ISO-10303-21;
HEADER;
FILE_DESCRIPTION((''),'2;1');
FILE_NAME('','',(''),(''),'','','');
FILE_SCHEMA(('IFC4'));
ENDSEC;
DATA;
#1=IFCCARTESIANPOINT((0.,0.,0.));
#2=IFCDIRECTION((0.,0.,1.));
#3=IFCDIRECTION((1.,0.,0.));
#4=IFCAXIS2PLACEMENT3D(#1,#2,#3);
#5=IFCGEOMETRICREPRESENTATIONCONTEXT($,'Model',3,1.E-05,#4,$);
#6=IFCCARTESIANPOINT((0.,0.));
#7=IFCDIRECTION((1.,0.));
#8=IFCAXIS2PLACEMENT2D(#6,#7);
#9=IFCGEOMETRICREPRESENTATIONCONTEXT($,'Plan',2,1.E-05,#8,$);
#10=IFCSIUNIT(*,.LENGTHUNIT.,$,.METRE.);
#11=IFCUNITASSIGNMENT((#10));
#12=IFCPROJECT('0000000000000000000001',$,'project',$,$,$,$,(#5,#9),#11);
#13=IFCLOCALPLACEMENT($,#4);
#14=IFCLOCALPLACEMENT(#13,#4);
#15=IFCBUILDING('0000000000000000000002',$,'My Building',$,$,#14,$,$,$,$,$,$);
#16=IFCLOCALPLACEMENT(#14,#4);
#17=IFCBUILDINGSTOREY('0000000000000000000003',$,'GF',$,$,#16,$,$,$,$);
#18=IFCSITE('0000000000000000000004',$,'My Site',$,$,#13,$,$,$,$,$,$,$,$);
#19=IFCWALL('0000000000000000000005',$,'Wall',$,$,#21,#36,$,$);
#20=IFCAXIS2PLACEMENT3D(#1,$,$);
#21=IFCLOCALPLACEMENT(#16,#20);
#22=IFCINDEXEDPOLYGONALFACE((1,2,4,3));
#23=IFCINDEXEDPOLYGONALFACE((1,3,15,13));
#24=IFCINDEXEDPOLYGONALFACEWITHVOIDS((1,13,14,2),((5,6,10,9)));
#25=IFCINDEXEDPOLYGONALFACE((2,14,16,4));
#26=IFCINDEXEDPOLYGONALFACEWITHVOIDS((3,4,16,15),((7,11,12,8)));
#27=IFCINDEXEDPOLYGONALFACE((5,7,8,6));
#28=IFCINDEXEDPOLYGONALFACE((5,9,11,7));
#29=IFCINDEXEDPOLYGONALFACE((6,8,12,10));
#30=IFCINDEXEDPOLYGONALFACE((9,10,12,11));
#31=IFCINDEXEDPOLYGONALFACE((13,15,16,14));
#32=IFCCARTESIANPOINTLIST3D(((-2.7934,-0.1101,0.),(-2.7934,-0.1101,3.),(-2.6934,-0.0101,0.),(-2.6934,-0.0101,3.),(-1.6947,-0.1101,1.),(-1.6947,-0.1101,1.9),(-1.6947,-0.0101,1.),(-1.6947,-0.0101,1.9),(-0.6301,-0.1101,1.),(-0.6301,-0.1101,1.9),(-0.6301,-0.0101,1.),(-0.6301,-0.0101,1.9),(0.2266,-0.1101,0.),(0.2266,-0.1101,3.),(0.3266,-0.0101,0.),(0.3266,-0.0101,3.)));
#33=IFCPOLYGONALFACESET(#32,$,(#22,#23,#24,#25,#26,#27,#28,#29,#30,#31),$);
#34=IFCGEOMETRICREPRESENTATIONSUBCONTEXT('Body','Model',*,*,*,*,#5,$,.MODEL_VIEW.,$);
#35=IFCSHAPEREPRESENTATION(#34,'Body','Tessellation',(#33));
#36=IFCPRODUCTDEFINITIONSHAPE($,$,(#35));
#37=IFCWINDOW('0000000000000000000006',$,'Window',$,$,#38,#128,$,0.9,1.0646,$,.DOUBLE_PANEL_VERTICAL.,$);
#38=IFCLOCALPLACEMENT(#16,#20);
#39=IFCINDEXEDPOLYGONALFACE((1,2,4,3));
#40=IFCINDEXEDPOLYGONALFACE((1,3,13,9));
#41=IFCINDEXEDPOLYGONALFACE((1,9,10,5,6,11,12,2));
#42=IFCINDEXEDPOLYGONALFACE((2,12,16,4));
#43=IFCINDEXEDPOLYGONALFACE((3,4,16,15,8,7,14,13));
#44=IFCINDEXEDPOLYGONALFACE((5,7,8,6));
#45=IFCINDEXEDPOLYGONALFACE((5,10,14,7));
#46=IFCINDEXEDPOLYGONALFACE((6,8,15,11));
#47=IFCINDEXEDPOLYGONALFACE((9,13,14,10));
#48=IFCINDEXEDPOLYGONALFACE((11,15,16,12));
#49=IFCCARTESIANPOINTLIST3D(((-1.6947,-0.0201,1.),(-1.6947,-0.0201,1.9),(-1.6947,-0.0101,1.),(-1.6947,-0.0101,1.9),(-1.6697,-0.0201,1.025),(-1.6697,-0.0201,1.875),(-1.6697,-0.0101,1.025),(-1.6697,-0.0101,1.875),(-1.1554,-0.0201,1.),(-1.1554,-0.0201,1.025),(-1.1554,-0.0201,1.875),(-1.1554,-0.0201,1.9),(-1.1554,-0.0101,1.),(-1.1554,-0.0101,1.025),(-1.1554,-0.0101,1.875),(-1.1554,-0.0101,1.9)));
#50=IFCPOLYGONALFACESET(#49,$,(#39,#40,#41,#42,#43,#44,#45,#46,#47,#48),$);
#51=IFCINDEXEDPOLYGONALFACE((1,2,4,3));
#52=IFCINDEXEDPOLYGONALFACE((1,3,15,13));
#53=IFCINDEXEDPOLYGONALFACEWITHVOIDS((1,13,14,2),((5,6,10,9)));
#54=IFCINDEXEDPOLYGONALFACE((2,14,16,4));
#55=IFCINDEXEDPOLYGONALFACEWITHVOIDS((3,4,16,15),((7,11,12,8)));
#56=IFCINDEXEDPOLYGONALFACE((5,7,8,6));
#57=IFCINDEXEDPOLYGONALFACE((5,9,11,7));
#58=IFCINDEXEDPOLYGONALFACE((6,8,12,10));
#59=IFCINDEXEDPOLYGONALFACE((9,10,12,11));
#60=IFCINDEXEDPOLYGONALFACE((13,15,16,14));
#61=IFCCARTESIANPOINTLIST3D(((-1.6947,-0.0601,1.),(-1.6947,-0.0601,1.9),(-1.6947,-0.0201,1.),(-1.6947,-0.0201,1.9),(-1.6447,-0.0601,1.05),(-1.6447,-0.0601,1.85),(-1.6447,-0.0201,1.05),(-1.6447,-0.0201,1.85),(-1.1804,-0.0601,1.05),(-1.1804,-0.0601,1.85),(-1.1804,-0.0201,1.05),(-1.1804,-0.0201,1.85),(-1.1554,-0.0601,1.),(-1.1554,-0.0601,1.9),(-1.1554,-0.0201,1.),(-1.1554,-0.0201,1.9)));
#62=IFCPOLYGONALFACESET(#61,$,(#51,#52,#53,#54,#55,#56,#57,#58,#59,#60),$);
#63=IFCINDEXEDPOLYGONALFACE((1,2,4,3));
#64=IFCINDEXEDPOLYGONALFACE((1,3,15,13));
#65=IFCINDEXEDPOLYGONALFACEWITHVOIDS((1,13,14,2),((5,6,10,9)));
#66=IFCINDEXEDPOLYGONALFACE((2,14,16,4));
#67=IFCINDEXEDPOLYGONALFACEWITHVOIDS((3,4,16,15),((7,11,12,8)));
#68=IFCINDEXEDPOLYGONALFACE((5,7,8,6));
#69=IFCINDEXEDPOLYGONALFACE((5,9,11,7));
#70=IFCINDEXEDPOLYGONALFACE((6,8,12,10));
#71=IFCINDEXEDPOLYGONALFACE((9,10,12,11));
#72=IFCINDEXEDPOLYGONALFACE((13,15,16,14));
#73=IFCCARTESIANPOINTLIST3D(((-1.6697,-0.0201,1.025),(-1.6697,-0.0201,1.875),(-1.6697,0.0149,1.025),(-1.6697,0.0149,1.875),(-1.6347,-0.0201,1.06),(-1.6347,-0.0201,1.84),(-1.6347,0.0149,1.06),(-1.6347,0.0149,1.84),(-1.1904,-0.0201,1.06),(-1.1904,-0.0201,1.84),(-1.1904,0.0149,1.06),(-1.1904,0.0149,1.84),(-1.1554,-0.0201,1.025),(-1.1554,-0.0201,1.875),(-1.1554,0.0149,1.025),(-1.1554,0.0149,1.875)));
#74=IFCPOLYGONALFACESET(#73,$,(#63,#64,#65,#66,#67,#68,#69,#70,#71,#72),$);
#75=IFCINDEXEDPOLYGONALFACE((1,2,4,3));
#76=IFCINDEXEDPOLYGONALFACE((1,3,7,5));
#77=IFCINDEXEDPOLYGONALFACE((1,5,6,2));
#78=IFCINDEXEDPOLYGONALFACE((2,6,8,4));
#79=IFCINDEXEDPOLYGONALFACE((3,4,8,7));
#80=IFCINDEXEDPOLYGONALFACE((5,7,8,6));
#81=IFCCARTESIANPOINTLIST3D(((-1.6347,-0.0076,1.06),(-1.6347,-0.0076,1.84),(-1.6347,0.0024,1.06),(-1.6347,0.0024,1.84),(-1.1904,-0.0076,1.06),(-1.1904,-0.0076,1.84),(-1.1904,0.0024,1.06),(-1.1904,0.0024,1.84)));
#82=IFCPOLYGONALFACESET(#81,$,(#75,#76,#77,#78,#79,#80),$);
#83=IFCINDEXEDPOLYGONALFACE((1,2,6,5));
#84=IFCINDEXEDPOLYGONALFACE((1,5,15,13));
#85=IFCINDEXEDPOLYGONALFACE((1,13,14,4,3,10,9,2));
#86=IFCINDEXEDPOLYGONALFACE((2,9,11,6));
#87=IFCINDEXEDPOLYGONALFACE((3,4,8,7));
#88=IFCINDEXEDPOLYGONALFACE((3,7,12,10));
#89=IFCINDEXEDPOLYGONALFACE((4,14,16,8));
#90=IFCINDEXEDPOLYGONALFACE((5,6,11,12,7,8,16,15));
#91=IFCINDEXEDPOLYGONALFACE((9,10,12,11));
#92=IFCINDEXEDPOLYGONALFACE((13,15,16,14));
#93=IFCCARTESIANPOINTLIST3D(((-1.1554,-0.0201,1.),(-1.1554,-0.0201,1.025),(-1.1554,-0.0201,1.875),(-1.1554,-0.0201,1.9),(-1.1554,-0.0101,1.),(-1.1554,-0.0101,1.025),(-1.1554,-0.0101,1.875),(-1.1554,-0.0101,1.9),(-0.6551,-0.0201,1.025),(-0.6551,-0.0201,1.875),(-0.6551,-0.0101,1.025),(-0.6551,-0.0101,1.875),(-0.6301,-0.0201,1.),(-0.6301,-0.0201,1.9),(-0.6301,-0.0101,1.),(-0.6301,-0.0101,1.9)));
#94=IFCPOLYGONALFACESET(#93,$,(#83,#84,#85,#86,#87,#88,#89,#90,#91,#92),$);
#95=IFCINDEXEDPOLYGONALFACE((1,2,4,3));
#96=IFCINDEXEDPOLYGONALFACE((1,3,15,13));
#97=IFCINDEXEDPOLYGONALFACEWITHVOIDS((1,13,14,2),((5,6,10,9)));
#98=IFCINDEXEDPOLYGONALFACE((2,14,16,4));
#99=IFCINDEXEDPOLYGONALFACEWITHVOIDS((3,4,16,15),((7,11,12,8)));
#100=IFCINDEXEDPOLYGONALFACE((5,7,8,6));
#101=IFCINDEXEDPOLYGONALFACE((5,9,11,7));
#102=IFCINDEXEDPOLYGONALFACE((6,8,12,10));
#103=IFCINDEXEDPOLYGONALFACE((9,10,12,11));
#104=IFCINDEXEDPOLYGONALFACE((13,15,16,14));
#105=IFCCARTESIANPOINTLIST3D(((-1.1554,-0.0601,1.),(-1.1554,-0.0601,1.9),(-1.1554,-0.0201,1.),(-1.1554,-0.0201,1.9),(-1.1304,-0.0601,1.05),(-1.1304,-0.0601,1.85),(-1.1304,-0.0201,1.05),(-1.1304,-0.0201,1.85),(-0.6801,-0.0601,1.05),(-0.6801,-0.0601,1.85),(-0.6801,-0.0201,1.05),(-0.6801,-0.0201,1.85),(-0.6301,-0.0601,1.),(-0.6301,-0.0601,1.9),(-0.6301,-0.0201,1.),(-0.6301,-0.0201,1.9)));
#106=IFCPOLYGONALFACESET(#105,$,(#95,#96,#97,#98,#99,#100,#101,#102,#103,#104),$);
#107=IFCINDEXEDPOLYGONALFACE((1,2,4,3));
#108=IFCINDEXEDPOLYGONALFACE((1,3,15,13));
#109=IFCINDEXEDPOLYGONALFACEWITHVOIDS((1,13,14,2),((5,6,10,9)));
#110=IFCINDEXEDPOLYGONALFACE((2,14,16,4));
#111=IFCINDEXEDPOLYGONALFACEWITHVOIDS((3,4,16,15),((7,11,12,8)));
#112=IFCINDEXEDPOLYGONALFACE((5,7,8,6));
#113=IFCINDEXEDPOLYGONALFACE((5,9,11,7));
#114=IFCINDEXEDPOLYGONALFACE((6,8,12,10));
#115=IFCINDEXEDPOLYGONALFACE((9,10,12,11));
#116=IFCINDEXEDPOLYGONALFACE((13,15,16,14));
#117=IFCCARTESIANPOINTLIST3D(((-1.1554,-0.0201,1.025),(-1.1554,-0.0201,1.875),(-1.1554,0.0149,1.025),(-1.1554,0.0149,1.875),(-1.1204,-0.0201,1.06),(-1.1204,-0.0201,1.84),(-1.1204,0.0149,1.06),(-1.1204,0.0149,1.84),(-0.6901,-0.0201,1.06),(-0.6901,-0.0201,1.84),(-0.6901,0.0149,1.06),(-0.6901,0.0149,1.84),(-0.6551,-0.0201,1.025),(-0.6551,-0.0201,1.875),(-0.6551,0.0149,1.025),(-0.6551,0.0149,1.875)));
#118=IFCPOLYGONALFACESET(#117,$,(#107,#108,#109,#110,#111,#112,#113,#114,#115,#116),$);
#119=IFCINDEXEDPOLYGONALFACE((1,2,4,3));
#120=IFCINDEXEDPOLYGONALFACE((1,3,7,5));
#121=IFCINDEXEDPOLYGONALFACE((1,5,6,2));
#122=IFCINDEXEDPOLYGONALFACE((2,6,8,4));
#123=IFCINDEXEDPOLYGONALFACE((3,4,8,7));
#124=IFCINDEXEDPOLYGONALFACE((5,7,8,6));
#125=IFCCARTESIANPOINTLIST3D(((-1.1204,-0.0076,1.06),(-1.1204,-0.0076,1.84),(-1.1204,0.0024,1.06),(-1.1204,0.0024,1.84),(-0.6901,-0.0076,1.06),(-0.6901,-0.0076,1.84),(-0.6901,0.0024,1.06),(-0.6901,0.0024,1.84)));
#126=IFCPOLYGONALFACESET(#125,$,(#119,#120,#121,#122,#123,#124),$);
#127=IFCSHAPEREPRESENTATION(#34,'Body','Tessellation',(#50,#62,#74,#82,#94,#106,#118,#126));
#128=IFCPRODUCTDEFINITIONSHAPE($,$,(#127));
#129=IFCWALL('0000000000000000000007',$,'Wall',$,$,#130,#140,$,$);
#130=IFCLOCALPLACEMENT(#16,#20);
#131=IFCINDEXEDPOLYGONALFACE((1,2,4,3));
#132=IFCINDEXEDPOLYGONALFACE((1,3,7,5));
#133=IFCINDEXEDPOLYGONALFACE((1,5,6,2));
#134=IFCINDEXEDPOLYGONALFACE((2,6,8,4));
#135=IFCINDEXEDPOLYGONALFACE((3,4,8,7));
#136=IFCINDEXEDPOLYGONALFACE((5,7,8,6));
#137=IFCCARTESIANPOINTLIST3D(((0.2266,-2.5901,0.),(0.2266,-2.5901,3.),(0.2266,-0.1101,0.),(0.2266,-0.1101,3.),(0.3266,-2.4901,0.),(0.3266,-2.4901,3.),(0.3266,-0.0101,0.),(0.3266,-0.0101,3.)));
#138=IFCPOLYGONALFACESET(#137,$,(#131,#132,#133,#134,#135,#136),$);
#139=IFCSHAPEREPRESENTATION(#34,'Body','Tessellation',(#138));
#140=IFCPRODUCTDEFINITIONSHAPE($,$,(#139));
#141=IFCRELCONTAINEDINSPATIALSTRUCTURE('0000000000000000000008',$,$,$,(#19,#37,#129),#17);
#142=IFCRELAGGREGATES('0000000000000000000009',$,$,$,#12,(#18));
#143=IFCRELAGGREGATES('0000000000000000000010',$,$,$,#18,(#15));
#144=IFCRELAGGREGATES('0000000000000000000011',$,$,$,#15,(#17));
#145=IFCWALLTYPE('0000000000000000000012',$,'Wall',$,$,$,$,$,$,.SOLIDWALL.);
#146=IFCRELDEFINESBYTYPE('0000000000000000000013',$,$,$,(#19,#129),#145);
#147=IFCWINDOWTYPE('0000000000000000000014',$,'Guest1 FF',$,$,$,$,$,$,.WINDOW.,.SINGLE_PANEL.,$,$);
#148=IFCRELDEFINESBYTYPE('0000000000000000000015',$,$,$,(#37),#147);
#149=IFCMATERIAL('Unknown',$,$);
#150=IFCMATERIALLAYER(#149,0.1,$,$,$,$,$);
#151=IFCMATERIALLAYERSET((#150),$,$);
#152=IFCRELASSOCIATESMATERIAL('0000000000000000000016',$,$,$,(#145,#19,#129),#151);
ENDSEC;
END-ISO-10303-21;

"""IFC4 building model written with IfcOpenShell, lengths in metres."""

from ifc_helpers import new_model, entity, si_unit, frame, origin_with_axes, origin_2d_with_axis, place, context, subcontext, project, spatial, line, indexed_curve, outline, extrude, shape, source, transform, mapped, material, layer, layer_set, layer_usage, type_object, type_shapes, element, fill, save


model = new_model("IFC4")

# Units and contexts
model_context = context("Model", 3, precision=1e-05, world=origin_with_axes())
plan_context = context("Plan", 2, precision=1e-05, world=origin_2d_with_axis())
body_context_1 = subcontext(model_context, "Body", "Model", "MODEL_VIEW")
body_context_2 = subcontext(plan_context, "Body", "Plan", "PLAN_VIEW")
ifc_project = project(units=[si_unit("LENGTHUNIT", "METRE")], contexts=[model_context, plan_context])

# Site, building, storey
site_placement = place(None, origin_with_axes())
site = spatial("IfcSite", under=ifc_project, at=site_placement, Name="My Site")
building_placement = place(site_placement, origin_with_axes())
building = spatial("IfcBuilding", under=site, at=building_placement, Name="My Building")
storey_placement = place(building_placement, origin_with_axes())
storey = spatial("IfcBuildingStorey", under=building, at=storey_placement, Name="GF")

# Shared definitions
ifc_material_1 = material(Name="Unknown")

# Shared definitions
ifc_layer_1 = layer(ifc_material_1, 0.1)
ifc_layer_set_1 = layer_set([ifc_layer_1])
wall_type = type_object("IfcWallType", Name="Wall", PredefinedType="SOLIDWALL", material=ifc_layer_set_1)

# Wall, opening, window
ifc_layer_usage_1 = layer_usage(ifc_layer_set_1, "AXIS2", "POSITIVE", 0.0)
wall_1_placement = place(storey_placement, frame((-2.7934, -0.1101, 0.0), z_axis=(0.0, 0.0, 1.0), x_axis=(1.0, 0.0, 0.0)))
wall_1 = element("IfcWall", 1, at=wall_1_placement, inside=storey, type_object=wall_type, material=ifc_layer_usage_1, Name="Wall", context=body_context_1, shape_type="SweptSolid", body=[
    extrude(outline(indexed_curve([(0.0, 0.0), (0.1, 0.1), (3.12, 0.1), (3.02, 0.0)], segments=[line(1, 2, 3, 4, 1)])), origin_with_axes(), (0.0, 0.0, 1.0), 3.0),
])
shared_shape_1 = source(origin_with_axes(), body_context_1, "Body", "SweptSolid", [
    extrude(outline(indexed_curve([(0.0, 0.0), (1.0646, 0.0), (1.0646, 0.9), (0.0, 0.9)], segments=[line(1, 2, 3, 4, 1)])), frame((0.0, -0.6, 0.0), z_axis=(0.0, -1.0, 0.0), x_axis=(1.0, 0.0, 0.0)), (0.0, 0.0, -1.0), 1.2),
])
opening_1_placement = place(wall_1_placement, frame((1.0987, 0.0, 1.0), z_axis=(0.0, 0.0, 1.0), x_axis=(1.0, 0.0, 0.0)))
opening_1 = element("IfcOpeningElement", 2, at=opening_1_placement, cuts=wall_1, PredefinedType="OPENING", context=body_context_1, shape_type="MappedRepresentation", body=[
    mapped(shared_shape_1, transform((0.0, 0.0, 0.0), x_axis=(1.0, 0.0, 0.0), y_axis=(0.0, 1.0, 0.0), z_axis=(0.0, 0.0, 1.0), scale=1.0)),
])
window_type_1 = type_object("IfcWindowType", Name="Guest1 FF", PartitioningType="SINGLE_PANEL", PredefinedType="WINDOW")
shared_shape_2 = source(origin_with_axes(), body_context_1, "Body", "SweptSolid", [
    extrude(outline(indexed_curve([(0.5393, 0.0), (0.0, 0.0), (0.0, 0.9), (0.5393, 0.9), (0.5393, 0.875), (0.025, 0.875), (0.025, 0.025), (0.5393, 0.025)], segments=[line(1, 2, 3, 4, 5, 6, 7, 8, 1)])), frame((0.0, 0.09, 0.0), z_axis=(0.0, -1.0, 0.0), x_axis=(1.0, 0.0, 0.0)), (0.0, 0.0, -1.0), 0.01),
    extrude(outline(indexed_curve([(0.0, 0.0), (0.5393, 0.0), (0.5393, 0.9), (0.0, 0.9)], segments=[line(1, 2, 3, 4, 1)]), holes=[indexed_curve([(0.05, 0.05), (0.5143, 0.05), (0.5143, 0.85), (0.05, 0.85)], segments=[line(1, 2, 3, 4, 1)])]), frame((0.0, 0.05, 0.0), z_axis=(0.0, -1.0, 0.0), x_axis=(1.0, 0.0, 0.0)), (0.0, 0.0, -1.0), 0.04),
    extrude(outline(indexed_curve([(0.0, 0.0), (0.5143, 0.0), (0.5143, 0.85), (0.0, 0.85)], segments=[line(1, 2, 3, 4, 1)]), holes=[indexed_curve([(0.035, 0.035), (0.4793, 0.035), (0.4793, 0.815), (0.035, 0.815)], segments=[line(1, 2, 3, 4, 1)])]), frame((0.025, 0.09, 0.025), z_axis=(0.0, -1.0, 0.0), x_axis=(1.0, 0.0, 0.0)), (0.0, 0.0, -1.0), 0.035),
    extrude(outline(indexed_curve([(0.035, 0.035), (0.4793, 0.035), (0.4793, 0.815), (0.035, 0.815)], segments=[line(1, 2, 3, 4, 1)])), frame((0.025, 0.1025, 0.025), z_axis=(0.0, -1.0, 0.0), x_axis=(1.0, 0.0, 0.0)), (0.0, 0.0, -1.0), 0.01),
    extrude(outline(indexed_curve([(0.0, 0.9), (0.5253, 0.9), (0.5253, 0.0), (0.0, 0.0), (0.0, 0.025), (0.5003, 0.025), (0.5003, 0.875), (0.0, 0.875)], segments=[line(1, 2, 3, 4, 5, 6, 7, 8, 1)])), frame((0.5393, 0.09, 0.0), z_axis=(0.0, -1.0, 0.0), x_axis=(1.0, 0.0, 0.0)), (0.0, 0.0, -1.0), 0.01),
    extrude(outline(indexed_curve([(0.0, 0.0), (0.5253, 0.0), (0.5253, 0.9), (0.0, 0.9)], segments=[line(1, 2, 3, 4, 1)]), holes=[indexed_curve([(0.025, 0.05), (0.4753, 0.05), (0.4753, 0.85), (0.025, 0.85)], segments=[line(1, 2, 3, 4, 1)])]), frame((0.5393, 0.05, 0.0), z_axis=(0.0, -1.0, 0.0), x_axis=(1.0, 0.0, 0.0)), (0.0, 0.0, -1.0), 0.04),
    extrude(outline(indexed_curve([(0.0, 0.0), (0.5003, 0.0), (0.5003, 0.85), (0.0, 0.85)], segments=[line(1, 2, 3, 4, 1)]), holes=[indexed_curve([(0.035, 0.035), (0.4653, 0.035), (0.4653, 0.815), (0.035, 0.815)], segments=[line(1, 2, 3, 4, 1)])]), frame((0.5393, 0.09, 0.025), z_axis=(0.0, -1.0, 0.0), x_axis=(1.0, 0.0, 0.0)), (0.0, 0.0, -1.0), 0.035),
    extrude(outline(indexed_curve([(0.035, 0.035), (0.4653, 0.035), (0.4653, 0.815), (0.035, 0.815)], segments=[line(1, 2, 3, 4, 1)])), frame((0.5393, 0.1025, 0.025), z_axis=(0.0, -1.0, 0.0), x_axis=(1.0, 0.0, 0.0)), (0.0, 0.0, -1.0), 0.01),
])
shared_shape_3 = source(origin_with_axes(), body_context_2, "Body", "Curve2D", [
    entity("IfcIndexedPolyCurve", entity("IfcCartesianPointList2D", [[0.05, 0.05], [0.5143, 0.05]])),
    entity("IfcIndexedPolyCurve", entity("IfcCartesianPointList2D", [[0.0, 0.1], [0.025, 0.1], [0.025, 0.09], [0.05, 0.09], [0.05, 0.05], [0.0, 0.05]]), [entity("IfcLineIndex", [1, 2, 3, 4, 5, 6, 1])]),
    entity("IfcIndexedPolyCurve", entity("IfcCartesianPointList2D", [[0.5393, 0.1], [0.5393, 0.1], [0.5393, 0.09], [0.5143, 0.09], [0.5143, 0.05], [0.5393, 0.05]])),
    entity("IfcIndexedPolyCurve", entity("IfcCartesianPointList2D", [[0.025, 0.09], [0.06, 0.09], [0.06, 0.125], [0.025, 0.125]]), [entity("IfcLineIndex", [1, 2, 3, 4, 1])]),
    entity("IfcIndexedPolyCurve", entity("IfcCartesianPointList2D", [[0.5393, 0.09], [0.5043, 0.09], [0.5043, 0.125], [0.5393, 0.125]]), [entity("IfcLineIndex", [1, 2, 3, 4, 1])]),
    entity("IfcIndexedPolyCurve", entity("IfcCartesianPointList2D", [[0.06, 0.09], [0.5043, 0.09]])),
    entity("IfcIndexedPolyCurve", entity("IfcCartesianPointList2D", [[0.06, 0.125], [0.5043, 0.125]])),
    entity("IfcIndexedPolyCurve", entity("IfcCartesianPointList2D", [[0.06, 0.1075], [0.5043, 0.1075]])),
    entity("IfcIndexedPolyCurve", entity("IfcCartesianPointList2D", [[0.5643, 0.05], [1.0146, 0.05]])),
    entity("IfcIndexedPolyCurve", entity("IfcCartesianPointList2D", [[0.5393, 0.1], [0.5393, 0.1], [0.5393, 0.09], [0.5643, 0.09], [0.5643, 0.05], [0.5393, 0.05]])),
    entity("IfcIndexedPolyCurve", entity("IfcCartesianPointList2D", [[1.0646, 0.1], [1.0396, 0.1], [1.0396, 0.09], [1.0146, 0.09], [1.0146, 0.05], [1.0646, 0.05]]), [entity("IfcLineIndex", [1, 2, 3, 4, 5, 6, 1])]),
    entity("IfcIndexedPolyCurve", entity("IfcCartesianPointList2D", [[0.5393, 0.09], [0.5743, 0.09], [0.5743, 0.125], [0.5393, 0.125]]), [entity("IfcLineIndex", [1, 2, 3, 4, 1])]),
    entity("IfcIndexedPolyCurve", entity("IfcCartesianPointList2D", [[1.0396, 0.09], [1.0046, 0.09], [1.0046, 0.125], [1.0396, 0.125]]), [entity("IfcLineIndex", [1, 2, 3, 4, 1])]),
    entity("IfcIndexedPolyCurve", entity("IfcCartesianPointList2D", [[0.5743, 0.09], [1.0046, 0.09]])),
    entity("IfcIndexedPolyCurve", entity("IfcCartesianPointList2D", [[0.5743, 0.125], [1.0046, 0.125]])),
    entity("IfcIndexedPolyCurve", entity("IfcCartesianPointList2D", [[0.5743, 0.1075], [1.0046, 0.1075]])),
])
type_shapes(window_type_1, [shared_shape_2, shared_shape_3])
window_1_placement = place(opening_1_placement, origin_with_axes())
window_1 = element("IfcWindow", 3, at=window_1_placement, inside=storey, type_object=window_type_1, Name="Window", OverallHeight=0.9, OverallWidth=1.0646, PartitioningType="DOUBLE_PANEL_VERTICAL", shapes=[
    shape(body_context_1, "Body", "MappedRepresentation", [mapped(shared_shape_2, transform((0.0, 0.0, 0.0), x_axis=(1.0, 0.0, 0.0), y_axis=(0.0, 1.0, 0.0), z_axis=(0.0, 0.0, 1.0), scale=1.0))]),
    shape(body_context_2, "Body", "MappedRepresentation", [mapped(shared_shape_3, transform((0.0, 0.0, 0.0), x_axis=(1.0, 0.0, 0.0), y_axis=(0.0, 1.0, 0.0), z_axis=(0.0, 0.0, 1.0), scale=1.0))]),
])
fill(opening_1, window_1)

# Wall
ifc_layer_usage_2 = layer_usage(ifc_layer_set_1, "AXIS2", "POSITIVE", 0.0)
wall_2_placement = place(storey_placement, frame((0.2266, -0.1101, 0.0), z_axis=(0.0, 0.0, 1.0), x_axis=(0.0, -1.0, 0.0)))
element("IfcWall", 4, at=wall_2_placement, inside=storey, type_object=wall_type, material=ifc_layer_usage_2, Name="Wall", context=body_context_1, shape_type="SweptSolid", body=[
    extrude(outline(indexed_curve([(0.0, 0.0), (-0.1, 0.1), (2.38, 0.1), (2.48, 0.0)], segments=[line(1, 2, 3, 4, 1)])), origin_with_axes(), (0.0, 0.0, 1.0), 3.0),
])

save(model, "model.ifc")
